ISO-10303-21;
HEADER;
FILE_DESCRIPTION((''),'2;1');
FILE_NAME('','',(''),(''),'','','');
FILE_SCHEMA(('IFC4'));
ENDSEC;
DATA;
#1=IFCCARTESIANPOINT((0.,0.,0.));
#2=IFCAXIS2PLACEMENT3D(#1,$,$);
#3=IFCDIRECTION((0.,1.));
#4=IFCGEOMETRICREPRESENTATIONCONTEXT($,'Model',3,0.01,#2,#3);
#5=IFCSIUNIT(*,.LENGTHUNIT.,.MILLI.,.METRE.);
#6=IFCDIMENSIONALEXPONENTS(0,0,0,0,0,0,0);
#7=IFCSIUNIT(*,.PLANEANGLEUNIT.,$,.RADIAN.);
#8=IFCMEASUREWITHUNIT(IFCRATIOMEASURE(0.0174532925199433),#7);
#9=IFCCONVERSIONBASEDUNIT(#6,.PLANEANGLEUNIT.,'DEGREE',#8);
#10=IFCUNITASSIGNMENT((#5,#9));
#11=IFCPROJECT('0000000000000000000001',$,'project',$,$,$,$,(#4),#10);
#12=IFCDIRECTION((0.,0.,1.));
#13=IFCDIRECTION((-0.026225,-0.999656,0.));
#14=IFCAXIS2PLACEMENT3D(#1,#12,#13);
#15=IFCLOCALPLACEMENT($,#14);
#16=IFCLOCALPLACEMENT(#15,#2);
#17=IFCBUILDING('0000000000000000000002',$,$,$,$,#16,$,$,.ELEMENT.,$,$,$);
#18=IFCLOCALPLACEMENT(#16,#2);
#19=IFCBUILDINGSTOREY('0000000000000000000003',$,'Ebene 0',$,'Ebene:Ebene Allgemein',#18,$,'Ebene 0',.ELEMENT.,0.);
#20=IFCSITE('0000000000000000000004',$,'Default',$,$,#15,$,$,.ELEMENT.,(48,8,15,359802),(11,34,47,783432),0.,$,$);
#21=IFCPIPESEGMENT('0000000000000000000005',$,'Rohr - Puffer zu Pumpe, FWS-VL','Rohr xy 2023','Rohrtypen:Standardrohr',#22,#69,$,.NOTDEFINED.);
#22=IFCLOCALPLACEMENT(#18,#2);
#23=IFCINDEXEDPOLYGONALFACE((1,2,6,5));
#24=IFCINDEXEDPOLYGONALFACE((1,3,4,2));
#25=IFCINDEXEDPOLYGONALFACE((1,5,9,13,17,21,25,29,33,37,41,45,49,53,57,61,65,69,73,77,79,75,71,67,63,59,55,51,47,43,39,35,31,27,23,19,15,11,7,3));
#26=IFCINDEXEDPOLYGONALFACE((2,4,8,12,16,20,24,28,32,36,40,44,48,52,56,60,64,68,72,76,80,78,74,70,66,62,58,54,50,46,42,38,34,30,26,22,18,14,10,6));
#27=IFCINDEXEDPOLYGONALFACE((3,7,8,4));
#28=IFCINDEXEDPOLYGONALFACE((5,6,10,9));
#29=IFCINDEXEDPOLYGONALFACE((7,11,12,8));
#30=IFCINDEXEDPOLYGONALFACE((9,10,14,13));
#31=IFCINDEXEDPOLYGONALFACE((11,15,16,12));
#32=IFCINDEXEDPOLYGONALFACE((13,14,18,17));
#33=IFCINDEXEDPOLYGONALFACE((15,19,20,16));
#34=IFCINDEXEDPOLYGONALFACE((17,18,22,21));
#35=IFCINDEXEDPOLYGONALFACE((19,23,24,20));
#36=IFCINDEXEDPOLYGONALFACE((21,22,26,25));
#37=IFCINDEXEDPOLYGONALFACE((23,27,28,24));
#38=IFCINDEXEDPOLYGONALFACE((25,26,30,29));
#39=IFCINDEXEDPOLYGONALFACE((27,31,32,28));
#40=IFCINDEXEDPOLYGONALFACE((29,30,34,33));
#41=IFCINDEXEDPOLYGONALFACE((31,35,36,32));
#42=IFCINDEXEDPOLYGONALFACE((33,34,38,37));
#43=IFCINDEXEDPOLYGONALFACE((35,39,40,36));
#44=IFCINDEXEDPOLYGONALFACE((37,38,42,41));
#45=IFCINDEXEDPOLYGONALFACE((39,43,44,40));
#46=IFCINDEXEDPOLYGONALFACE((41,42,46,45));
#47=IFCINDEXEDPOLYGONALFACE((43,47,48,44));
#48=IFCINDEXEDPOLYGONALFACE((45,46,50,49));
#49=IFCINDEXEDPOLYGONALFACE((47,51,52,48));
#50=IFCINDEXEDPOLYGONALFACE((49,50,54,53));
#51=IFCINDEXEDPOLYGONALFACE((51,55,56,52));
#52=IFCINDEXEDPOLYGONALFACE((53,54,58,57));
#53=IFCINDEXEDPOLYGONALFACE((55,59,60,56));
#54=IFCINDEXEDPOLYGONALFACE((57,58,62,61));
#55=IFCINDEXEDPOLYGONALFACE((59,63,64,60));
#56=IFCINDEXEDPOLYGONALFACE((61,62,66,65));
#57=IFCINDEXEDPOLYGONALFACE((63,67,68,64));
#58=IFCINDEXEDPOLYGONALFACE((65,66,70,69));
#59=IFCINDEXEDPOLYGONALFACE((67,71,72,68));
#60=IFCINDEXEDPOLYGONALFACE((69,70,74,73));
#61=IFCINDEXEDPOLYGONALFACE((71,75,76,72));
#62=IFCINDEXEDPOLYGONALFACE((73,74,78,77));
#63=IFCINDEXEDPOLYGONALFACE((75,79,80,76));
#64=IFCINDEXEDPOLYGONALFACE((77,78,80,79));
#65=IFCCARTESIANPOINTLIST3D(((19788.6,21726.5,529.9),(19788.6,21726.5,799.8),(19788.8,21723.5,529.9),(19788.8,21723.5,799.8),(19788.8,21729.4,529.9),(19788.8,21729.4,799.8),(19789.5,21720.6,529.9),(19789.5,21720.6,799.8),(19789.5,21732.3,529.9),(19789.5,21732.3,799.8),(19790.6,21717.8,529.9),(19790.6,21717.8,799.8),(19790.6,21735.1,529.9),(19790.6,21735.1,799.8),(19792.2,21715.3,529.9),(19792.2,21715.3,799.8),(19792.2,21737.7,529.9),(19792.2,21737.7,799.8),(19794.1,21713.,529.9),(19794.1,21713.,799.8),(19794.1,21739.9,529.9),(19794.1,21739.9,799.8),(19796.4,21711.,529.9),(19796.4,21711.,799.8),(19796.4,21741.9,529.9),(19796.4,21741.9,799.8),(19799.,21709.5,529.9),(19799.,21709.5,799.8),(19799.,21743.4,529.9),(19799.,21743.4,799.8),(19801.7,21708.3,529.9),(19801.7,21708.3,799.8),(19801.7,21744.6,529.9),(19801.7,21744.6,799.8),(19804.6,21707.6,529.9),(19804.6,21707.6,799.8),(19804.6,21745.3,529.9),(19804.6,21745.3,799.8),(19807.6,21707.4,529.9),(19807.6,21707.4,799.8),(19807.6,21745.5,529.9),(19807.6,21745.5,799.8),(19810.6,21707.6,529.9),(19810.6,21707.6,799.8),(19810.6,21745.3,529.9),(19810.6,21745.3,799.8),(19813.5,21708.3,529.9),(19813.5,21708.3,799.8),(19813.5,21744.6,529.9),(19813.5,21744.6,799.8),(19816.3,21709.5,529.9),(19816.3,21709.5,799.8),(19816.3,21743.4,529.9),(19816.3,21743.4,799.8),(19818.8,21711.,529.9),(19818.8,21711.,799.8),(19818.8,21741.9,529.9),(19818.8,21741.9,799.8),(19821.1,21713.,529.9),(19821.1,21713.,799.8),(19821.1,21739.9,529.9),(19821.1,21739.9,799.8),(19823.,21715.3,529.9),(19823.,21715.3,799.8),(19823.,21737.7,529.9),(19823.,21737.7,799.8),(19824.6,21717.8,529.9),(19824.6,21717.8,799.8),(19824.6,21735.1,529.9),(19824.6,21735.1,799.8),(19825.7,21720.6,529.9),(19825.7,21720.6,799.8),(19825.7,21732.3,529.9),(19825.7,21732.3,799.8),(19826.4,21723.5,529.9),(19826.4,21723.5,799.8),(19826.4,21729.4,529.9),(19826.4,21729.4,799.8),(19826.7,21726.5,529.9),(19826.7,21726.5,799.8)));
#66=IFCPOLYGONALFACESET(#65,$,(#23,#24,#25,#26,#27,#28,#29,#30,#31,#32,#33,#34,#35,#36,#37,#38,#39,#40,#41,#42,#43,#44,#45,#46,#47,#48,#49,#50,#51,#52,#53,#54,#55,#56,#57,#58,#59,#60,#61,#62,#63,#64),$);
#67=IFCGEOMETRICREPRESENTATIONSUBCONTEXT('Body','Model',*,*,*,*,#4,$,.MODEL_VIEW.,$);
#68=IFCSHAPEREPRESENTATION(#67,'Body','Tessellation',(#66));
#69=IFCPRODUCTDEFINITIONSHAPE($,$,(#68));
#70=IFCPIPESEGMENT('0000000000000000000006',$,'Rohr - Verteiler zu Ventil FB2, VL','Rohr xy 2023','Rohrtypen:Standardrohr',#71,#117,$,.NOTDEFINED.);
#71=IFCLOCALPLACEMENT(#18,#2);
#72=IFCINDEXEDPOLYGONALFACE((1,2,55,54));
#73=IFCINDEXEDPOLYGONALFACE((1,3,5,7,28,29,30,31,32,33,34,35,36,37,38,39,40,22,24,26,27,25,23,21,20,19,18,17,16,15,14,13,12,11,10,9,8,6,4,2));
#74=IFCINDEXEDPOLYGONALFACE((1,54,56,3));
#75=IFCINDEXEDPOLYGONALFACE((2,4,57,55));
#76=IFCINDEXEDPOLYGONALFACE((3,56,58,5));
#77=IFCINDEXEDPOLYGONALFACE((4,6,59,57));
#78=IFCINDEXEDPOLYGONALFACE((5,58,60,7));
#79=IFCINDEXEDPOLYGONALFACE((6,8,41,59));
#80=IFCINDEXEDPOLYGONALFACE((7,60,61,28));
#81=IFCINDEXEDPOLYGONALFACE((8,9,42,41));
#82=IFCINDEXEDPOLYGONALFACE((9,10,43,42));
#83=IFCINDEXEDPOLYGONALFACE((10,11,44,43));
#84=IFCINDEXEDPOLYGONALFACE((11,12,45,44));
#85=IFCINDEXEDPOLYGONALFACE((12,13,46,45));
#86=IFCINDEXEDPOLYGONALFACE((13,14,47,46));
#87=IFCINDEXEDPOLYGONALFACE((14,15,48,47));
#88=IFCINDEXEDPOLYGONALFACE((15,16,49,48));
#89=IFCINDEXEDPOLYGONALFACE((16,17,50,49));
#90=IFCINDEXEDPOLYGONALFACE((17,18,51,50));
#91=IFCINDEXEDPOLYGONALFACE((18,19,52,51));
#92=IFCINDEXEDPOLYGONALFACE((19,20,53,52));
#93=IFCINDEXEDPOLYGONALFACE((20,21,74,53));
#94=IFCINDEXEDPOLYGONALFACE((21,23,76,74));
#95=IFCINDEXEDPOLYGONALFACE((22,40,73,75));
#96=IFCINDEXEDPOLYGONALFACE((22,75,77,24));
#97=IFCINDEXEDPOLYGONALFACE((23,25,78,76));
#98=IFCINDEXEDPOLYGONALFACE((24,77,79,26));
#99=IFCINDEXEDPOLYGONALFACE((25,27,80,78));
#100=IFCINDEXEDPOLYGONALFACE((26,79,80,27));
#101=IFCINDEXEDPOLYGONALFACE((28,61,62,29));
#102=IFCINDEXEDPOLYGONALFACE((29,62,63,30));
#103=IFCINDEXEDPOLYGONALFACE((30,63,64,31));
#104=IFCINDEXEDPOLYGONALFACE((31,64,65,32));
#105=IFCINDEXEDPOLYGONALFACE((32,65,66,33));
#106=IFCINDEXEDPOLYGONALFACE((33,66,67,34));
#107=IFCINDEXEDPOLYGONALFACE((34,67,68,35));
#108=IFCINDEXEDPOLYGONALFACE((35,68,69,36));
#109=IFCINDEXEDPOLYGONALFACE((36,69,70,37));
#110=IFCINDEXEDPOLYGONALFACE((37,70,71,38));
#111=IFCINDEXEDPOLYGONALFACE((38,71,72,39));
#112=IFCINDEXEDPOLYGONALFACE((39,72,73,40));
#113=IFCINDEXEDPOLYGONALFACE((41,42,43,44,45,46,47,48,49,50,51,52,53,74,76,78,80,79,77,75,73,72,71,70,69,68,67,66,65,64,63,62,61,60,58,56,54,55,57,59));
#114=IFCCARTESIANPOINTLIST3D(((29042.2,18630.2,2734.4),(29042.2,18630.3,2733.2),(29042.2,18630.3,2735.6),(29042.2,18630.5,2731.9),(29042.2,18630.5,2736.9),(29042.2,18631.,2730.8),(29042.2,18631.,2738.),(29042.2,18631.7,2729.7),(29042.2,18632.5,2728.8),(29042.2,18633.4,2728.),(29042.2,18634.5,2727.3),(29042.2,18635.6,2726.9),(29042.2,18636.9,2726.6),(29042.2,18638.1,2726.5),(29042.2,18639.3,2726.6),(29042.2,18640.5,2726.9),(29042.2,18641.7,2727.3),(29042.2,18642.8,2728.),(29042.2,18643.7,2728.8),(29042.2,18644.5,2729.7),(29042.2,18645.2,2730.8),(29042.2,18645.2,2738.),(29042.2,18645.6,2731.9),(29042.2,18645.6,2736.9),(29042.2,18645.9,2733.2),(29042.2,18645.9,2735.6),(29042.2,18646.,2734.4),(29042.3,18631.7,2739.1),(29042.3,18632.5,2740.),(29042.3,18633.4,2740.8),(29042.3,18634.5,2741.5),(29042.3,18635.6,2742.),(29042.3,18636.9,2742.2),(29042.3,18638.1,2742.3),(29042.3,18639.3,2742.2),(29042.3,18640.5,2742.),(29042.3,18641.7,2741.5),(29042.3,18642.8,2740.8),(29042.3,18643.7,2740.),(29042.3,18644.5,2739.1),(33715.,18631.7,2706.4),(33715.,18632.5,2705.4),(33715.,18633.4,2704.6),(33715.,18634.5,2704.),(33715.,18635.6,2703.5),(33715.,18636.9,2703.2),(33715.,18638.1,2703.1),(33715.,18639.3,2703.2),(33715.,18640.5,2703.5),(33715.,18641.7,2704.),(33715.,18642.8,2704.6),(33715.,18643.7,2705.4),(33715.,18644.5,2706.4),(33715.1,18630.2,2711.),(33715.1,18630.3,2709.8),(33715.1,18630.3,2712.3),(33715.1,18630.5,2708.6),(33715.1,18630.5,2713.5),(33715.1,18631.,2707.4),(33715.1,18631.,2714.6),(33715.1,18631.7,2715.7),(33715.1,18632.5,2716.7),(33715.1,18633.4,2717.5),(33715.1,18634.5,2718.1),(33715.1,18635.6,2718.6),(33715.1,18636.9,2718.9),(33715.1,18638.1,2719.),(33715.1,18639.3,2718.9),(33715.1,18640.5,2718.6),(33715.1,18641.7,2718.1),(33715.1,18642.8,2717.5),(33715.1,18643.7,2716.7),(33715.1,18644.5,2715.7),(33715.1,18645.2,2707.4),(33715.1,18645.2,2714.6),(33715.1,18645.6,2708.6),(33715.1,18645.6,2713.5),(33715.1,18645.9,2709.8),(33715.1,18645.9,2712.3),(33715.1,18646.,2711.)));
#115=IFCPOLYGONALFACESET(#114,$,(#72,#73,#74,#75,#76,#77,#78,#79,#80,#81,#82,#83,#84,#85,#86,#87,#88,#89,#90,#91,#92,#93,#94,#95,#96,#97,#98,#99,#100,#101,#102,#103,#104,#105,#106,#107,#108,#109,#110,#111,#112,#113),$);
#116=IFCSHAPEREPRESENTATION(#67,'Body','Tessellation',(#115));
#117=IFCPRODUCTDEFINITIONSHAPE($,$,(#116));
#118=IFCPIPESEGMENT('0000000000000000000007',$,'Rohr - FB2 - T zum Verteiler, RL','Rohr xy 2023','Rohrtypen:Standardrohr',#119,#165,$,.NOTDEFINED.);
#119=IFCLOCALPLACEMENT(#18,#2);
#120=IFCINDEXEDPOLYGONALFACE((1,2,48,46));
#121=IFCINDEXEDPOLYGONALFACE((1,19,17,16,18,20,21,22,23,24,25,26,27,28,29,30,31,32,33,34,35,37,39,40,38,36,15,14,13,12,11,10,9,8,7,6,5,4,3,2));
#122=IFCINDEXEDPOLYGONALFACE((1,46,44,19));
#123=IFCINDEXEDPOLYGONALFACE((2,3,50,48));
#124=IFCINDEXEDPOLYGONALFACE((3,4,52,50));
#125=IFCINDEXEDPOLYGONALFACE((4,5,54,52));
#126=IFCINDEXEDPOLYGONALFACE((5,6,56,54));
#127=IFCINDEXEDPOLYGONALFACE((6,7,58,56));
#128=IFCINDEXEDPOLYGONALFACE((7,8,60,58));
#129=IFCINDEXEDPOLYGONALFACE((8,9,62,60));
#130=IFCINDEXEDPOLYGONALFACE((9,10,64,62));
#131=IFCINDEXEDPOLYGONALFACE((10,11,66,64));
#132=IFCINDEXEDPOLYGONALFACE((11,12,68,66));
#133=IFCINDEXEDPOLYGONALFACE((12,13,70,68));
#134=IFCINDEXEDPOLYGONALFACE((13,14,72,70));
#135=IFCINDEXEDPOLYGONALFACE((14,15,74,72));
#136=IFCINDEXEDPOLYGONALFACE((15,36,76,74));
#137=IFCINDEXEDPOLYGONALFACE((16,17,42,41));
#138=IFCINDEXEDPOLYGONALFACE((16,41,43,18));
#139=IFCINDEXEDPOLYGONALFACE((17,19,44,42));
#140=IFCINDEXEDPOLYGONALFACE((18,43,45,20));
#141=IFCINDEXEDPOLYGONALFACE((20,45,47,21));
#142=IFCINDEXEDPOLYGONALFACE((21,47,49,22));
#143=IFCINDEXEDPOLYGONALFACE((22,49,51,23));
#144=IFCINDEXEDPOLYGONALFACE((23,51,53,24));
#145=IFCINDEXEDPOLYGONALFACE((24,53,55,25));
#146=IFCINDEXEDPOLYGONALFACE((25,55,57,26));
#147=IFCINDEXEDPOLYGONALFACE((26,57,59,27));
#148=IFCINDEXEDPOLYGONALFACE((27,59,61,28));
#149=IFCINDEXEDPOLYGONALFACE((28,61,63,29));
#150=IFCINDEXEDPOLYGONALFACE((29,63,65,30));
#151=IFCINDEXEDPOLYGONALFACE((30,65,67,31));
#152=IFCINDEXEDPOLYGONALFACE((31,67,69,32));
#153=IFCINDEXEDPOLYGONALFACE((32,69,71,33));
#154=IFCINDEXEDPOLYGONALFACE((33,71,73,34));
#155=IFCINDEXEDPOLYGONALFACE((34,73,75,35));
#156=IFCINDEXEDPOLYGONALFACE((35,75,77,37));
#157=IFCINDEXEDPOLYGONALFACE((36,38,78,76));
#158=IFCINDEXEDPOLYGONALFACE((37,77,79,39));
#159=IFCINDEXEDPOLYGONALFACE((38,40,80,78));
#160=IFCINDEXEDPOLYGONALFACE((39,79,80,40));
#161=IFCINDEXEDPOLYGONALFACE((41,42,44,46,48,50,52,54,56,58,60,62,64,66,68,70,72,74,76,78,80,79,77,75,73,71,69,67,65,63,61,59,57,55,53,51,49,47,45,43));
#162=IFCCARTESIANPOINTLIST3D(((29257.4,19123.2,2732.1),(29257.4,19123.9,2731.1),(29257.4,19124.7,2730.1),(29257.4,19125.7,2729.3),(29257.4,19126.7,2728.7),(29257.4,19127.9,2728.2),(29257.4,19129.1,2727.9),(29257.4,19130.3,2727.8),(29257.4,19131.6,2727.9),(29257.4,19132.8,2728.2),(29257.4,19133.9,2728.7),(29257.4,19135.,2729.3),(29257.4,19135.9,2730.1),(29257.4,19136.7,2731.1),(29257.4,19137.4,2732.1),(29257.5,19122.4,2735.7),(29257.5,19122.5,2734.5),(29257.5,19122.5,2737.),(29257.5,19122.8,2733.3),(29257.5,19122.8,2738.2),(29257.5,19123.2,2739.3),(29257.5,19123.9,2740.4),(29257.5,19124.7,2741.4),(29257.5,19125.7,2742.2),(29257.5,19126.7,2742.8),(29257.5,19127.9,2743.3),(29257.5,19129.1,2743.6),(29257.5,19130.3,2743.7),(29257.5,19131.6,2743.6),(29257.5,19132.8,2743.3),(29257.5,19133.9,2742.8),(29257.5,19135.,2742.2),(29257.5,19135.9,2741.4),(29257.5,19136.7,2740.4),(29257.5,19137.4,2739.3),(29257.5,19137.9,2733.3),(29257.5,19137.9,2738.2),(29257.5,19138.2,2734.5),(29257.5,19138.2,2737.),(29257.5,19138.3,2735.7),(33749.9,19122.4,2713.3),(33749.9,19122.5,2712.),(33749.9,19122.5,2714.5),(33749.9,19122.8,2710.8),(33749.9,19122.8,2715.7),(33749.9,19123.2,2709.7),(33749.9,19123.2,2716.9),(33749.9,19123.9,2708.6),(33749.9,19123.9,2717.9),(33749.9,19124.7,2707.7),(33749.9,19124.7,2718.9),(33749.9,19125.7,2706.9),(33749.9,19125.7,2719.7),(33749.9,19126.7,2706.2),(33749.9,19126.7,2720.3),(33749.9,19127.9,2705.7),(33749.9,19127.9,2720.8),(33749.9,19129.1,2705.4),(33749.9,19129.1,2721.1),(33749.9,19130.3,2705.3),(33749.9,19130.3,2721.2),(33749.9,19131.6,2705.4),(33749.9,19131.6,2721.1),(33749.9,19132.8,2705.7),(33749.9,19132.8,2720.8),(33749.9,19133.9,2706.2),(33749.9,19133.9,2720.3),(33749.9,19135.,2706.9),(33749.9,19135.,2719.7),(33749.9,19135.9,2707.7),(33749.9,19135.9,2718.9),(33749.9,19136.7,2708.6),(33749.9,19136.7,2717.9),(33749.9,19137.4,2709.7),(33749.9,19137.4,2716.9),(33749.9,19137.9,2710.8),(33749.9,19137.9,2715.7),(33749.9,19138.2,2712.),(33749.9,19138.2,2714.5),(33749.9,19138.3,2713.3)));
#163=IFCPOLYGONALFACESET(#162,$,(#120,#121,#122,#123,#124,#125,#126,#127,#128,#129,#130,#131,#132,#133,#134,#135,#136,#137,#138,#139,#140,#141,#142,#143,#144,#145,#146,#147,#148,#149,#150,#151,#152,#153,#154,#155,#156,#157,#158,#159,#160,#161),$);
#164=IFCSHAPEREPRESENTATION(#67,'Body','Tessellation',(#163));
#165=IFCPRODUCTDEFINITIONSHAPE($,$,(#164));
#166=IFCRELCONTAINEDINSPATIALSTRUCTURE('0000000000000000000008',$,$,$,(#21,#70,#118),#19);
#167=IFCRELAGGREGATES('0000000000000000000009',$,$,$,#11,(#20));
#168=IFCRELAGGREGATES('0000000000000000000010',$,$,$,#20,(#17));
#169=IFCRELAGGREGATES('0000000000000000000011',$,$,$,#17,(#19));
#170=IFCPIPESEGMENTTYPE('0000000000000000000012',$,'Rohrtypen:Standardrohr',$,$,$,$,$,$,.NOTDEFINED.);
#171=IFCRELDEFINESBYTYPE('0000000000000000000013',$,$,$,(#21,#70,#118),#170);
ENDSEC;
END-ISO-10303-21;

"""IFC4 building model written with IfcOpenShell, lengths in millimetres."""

from ifc_helpers import new_model, entity, si_unit, converted_unit, direction, frame, origin, place, context, subcontext, project, spatial, indexed_curve, outline, extrude, type_object, element, save


model = new_model("IFC4")

# Units and contexts
model_context = context("Model", 3, precision=0.01, world=origin(), true_north=direction((0.0, 1.0)))
body_context = subcontext(model_context, "Body", "Model", "MODEL_VIEW")
ifc_project = project(units=[si_unit("LENGTHUNIT", "METRE", prefix="MILLI"), converted_unit("PLANEANGLEUNIT", "DEGREE", entity("IfcRatioMeasure", 0.0174532925199433), si_unit("PLANEANGLEUNIT", "RADIAN"), dimensions=[0, 0, 0, 0, 0, 0, 0])], contexts=[model_context])

# Site, building, storey
site_placement = place(None, frame((0.0, 0.0, 0.0), z_axis=(0.0, 0.0, 1.0), x_axis=(-0.026225, -0.999656, 0.0)))
site = spatial("IfcSite", under=ifc_project, at=site_placement, Name="Default", CompositionType="ELEMENT", RefLatitude=(48, 8, 15, 359802), RefLongitude=(11, 34, 47, 783432), RefElevation=0.0)
building_placement = place(site_placement, origin())
building = spatial("IfcBuilding", under=site, at=building_placement, CompositionType="ELEMENT")
storey_placement = place(building_placement, origin())
storey = spatial("IfcBuildingStorey", under=building, at=storey_placement, Name="Ebene 0", ObjectType="Ebene:Ebene Allgemein", LongName="Ebene 0", CompositionType="ELEMENT", Elevation=0.0)

# Pipe segments
pipe_segment_type = type_object("IfcPipeSegmentType", Name="Rohrtypen:Standardrohr", PredefinedType="NOTDEFINED")
pipe_segment_1_placement = place(storey_placement, origin())
element("IfcPipeSegment", 1, at=pipe_segment_1_placement, inside=storey, type_object=pipe_segment_type, Name="Rohr - Puffer zu Pumpe, FWS-VL", Description="Rohr xy 2023", ObjectType="Rohrtypen:Standardrohr", PredefinedType="NOTDEFINED", context=body_context, shape_type="SweptSolid", body=[
    extrude(outline(indexed_curve([(19.1, 0.0), (18.8, 3.0), (18.1, 5.9), (17.0, 8.6), (15.4, 11.2), (13.5, 13.5), (11.2, 15.4), (8.6, 17.0), (5.9, 18.1), (3.0, 18.8), (0.0, 19.0), (-3.0, 18.8), (-5.9, 18.1), (-8.6, 17.0), (-11.2, 15.4), (-13.5, 13.5), (-15.4, 11.2), (-17.0, 8.6), (-18.1, 5.9), (-18.8, 3.0), (-19.1, 0.0), (-18.8, -3.0), (-18.1, -5.9), (-17.0, -8.6), (-15.4, -11.2), (-13.5, -13.5), (-11.2, -15.4), (-8.6, -17.0), (-5.9, -18.1), (-3.0, -18.8), (0.0, -19.0), (3.0, -18.8), (5.9, -18.1), (8.6, -17.0), (11.2, -15.4), (13.5, -13.5), (15.4, -11.2), (17.0, -8.6), (18.1, -5.9), (18.8, -3.0), (19.1, 0.0)], self_intersect=False)), frame((19807.6, 21726.5, 529.9), z_axis=(0.000002, 0.000002, 1.0), x_axis=(-1.0, 0.0, 0.000002)), (0.0, 0.0, 1.0), 269.9),
])
pipe_segment_2_placement = place(storey_placement, origin())
element("IfcPipeSegment", 2, at=pipe_segment_2_placement, inside=storey, type_object=pipe_segment_type, Name="Rohr - Verteiler zu Ventil FB2, VL", Description="Rohr xy 2023", ObjectType="Rohrtypen:Standardrohr", PredefinedType="NOTDEFINED", context=body_context, shape_type="SweptSolid", body=[
    extrude(outline(indexed_curve([(7.9, 0.0), (7.8, 1.2), (7.6, 2.5), (7.1, 3.6), (6.4, 4.7), (5.6, 5.6), (4.7, 6.4), (3.6, 7.1), (2.5, 7.6), (1.2, 7.8), (0.0, 7.9), (-1.2, 7.8), (-2.5, 7.6), (-3.6, 7.1), (-4.7, 6.4), (-5.6, 5.6), (-6.4, 4.7), (-7.1, 3.6), (-7.6, 2.5), (-7.8, 1.2), (-7.9, 0.0), (-7.8, -1.2), (-7.6, -2.5), (-7.1, -3.6), (-6.4, -4.7), (-5.6, -5.6), (-4.7, -6.4), (-3.6, -7.1), (-2.5, -7.6), (-1.2, -7.8), (0.0, -7.9), (1.2, -7.8), (2.5, -7.6), (3.6, -7.1), (4.7, -6.4), (5.6, -5.6), (6.4, -4.7), (7.1, -3.6), (7.6, -2.5), (7.8, -1.2), (7.9, 0.0)], self_intersect=False)), frame((33715.1, 18638.1, 2711.0), z_axis=(-0.999988, 0.0, 0.005), x_axis=(0.0, 1.0, 0.0)), (0.0, 0.0, 1.0), 4672.9),
])
pipe_segment_3_placement = place(storey_placement, origin())
element("IfcPipeSegment", 3, at=pipe_segment_3_placement, inside=storey, type_object=pipe_segment_type, Name="Rohr - FB2 - T zum Verteiler, RL", Description="Rohr xy 2023", ObjectType="Rohrtypen:Standardrohr", PredefinedType="NOTDEFINED", context=body_context, shape_type="SweptSolid", body=[
    extrude(outline(indexed_curve([(7.9, 0.0), (7.8, 1.2), (7.6, 2.5), (7.1, 3.6), (6.4, 4.7), (5.6, 5.6), (4.7, 6.4), (3.6, 7.1), (2.5, 7.6), (1.2, 7.8), (0.0, 7.9), (-1.2, 7.8), (-2.5, 7.6), (-3.6, 7.1), (-4.7, 6.4), (-5.6, 5.6), (-6.4, 4.7), (-7.1, 3.6), (-7.6, 2.5), (-7.8, 1.2), (-7.9, 0.0), (-7.8, -1.2), (-7.6, -2.5), (-7.1, -3.6), (-6.4, -4.7), (-5.6, -5.6), (-4.7, -6.4), (-3.6, -7.1), (-2.5, -7.6), (-1.2, -7.8), (0.0, -7.9), (1.2, -7.8), (2.5, -7.6), (3.6, -7.1), (4.7, -6.4), (5.6, -5.6), (6.4, -4.7), (7.1, -3.6), (7.6, -2.5), (7.8, -1.2), (7.9, 0.0)], self_intersect=False)), frame((33749.9, 19130.3, 2713.3), z_axis=(-0.999988, 0.0, 0.005), x_axis=(0.0, 1.0, 0.0)), (0.0, 0.0, 1.0), 4492.5),
])

save(model, "model.ifc")
